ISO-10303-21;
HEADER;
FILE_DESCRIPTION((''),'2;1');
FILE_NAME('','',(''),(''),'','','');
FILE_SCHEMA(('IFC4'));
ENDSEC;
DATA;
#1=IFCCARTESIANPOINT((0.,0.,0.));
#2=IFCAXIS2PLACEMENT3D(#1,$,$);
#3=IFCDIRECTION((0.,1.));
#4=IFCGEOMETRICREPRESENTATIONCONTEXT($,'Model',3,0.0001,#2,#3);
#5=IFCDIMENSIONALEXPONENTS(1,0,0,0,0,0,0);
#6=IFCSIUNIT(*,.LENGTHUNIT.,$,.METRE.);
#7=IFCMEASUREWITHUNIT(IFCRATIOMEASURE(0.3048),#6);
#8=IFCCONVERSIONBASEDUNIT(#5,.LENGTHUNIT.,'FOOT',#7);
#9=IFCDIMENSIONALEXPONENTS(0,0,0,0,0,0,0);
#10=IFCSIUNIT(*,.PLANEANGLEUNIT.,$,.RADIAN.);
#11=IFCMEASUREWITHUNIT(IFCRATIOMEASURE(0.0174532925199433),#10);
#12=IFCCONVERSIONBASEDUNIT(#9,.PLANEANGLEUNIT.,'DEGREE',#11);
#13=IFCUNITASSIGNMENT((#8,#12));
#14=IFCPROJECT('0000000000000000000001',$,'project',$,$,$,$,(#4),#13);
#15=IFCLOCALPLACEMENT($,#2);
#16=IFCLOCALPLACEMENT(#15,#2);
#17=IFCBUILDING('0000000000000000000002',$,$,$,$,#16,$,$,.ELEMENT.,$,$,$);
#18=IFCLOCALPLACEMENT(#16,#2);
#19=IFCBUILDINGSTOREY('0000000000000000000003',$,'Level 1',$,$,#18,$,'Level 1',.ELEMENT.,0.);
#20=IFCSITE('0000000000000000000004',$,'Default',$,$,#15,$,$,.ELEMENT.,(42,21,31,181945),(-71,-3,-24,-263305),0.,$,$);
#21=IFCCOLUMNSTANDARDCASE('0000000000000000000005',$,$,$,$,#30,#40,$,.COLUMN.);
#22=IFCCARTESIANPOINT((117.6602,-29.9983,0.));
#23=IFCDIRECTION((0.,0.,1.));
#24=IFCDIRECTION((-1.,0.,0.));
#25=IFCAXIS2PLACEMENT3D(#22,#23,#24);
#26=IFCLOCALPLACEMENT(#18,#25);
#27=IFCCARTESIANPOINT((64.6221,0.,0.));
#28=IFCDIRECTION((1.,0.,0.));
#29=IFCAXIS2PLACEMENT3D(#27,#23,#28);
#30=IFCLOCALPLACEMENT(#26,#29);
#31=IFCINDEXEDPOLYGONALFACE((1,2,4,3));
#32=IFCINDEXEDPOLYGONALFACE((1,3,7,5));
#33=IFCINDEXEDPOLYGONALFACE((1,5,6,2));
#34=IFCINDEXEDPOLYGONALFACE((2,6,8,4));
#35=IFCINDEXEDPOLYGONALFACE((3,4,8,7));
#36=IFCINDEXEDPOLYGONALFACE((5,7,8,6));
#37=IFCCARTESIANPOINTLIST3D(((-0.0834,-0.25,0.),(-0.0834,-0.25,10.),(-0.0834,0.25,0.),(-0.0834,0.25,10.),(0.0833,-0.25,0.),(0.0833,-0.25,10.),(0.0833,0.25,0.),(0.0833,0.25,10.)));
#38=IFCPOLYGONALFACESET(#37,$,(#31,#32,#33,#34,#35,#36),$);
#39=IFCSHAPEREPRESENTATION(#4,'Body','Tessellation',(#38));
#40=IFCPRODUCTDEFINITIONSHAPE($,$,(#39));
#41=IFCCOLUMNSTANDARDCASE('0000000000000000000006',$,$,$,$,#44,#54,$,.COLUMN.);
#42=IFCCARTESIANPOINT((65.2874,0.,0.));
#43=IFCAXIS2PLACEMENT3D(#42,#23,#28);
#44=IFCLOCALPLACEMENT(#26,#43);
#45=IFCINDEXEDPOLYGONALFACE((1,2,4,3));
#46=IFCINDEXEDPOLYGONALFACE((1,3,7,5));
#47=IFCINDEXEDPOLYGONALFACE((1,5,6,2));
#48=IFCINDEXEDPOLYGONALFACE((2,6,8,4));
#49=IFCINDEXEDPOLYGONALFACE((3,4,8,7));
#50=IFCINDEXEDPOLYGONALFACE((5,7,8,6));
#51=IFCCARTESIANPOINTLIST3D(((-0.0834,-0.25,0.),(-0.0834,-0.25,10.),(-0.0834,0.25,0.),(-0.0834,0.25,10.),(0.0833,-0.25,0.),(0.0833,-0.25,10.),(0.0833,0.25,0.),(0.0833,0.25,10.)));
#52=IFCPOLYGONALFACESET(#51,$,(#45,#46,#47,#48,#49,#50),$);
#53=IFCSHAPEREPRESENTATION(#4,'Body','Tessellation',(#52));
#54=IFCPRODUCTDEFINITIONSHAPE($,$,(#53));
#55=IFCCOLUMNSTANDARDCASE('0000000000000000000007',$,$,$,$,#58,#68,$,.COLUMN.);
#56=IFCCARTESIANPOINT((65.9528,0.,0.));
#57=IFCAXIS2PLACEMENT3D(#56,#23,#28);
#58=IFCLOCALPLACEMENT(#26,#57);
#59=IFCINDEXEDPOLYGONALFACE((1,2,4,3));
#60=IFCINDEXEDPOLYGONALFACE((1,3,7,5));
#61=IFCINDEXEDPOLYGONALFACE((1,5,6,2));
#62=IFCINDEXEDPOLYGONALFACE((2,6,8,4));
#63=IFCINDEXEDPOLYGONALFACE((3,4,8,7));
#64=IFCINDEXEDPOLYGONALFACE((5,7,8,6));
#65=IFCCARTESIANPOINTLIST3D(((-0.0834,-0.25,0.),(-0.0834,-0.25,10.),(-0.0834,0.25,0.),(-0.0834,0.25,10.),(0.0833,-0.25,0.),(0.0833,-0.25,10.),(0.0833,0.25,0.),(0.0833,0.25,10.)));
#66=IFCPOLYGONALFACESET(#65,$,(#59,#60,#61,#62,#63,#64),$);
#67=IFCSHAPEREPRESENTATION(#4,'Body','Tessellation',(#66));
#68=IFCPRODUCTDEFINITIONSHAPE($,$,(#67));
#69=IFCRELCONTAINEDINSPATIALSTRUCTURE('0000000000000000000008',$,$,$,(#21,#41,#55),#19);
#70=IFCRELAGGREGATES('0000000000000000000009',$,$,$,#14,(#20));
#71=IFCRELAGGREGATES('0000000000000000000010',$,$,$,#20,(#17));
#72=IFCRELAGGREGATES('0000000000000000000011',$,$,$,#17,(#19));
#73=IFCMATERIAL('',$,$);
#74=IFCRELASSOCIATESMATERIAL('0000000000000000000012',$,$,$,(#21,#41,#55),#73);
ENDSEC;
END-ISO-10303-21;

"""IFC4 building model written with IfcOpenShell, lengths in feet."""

from ifc_helpers import new_model, entity, si_unit, converted_unit, direction, frame, origin, place, context, project, spatial, rectangle, extrude, material, element, save


model = new_model("IFC4")

# Units and contexts
model_context = context("Model", 3, precision=0.0001, world=origin(), true_north=direction((0.0, 1.0)))
ifc_project = project(units=[converted_unit("LENGTHUNIT", "FOOT", entity("IfcRatioMeasure", 0.3048), si_unit("LENGTHUNIT", "METRE"), dimensions=[1, 0, 0, 0, 0, 0, 0]), converted_unit("PLANEANGLEUNIT", "DEGREE", entity("IfcRatioMeasure", 0.0174532925199433), si_unit("PLANEANGLEUNIT", "RADIAN"), dimensions=[0, 0, 0, 0, 0, 0, 0])], contexts=[model_context])

# Site, building, storey
site_placement = place(None, origin())
site = spatial("IfcSite", under=ifc_project, at=site_placement, Name="Default", CompositionType="ELEMENT", RefLatitude=(42, 21, 31, 181945), RefLongitude=(-71, -3, -24, -263305), RefElevation=0.0)
building_placement = place(site_placement, origin())
building = spatial("IfcBuilding", under=site, at=building_placement, CompositionType="ELEMENT")
storey_placement = place(building_placement, origin())
storey = spatial("IfcBuildingStorey", under=building, at=storey_placement, Name="Level 1", LongName="Level 1", CompositionType="ELEMENT", Elevation=0.0)

# Columns
ifc_material = material(Name="")
placement = place(storey_placement, frame((117.6602, -29.9983, 0.0), z_axis=(0.0, 0.0, 1.0), x_axis=(-1.0, 0.0, 0.0)))
for number, where, z_axis, x_axis in (
    (1, (64.6221, 0.0, 0.0), (0.0, 0.0, 1.0), (1.0, 0.0, 0.0)),
    (2, (65.2874, 0.0, 0.0), (0.0, 0.0, 1.0), (1.0, 0.0, 0.0)),
    (3, (65.9528, 0.0, 0.0), (0.0, 0.0, 1.0), (1.0, 0.0, 0.0)),
):
    element("IfcColumnStandardCase", number, at=place(placement, frame(where, z_axis=z_axis, x_axis=x_axis)), inside=storey, material=ifc_material, PredefinedType="COLUMN", context=model_context, shape_type="SweptSolid", body=[
        extrude(rectangle(XDim=0.1667, YDim=0.5), origin(), (0.0, 0.0, 1.0), 10.0),
    ])

save(model, "model.ifc")
